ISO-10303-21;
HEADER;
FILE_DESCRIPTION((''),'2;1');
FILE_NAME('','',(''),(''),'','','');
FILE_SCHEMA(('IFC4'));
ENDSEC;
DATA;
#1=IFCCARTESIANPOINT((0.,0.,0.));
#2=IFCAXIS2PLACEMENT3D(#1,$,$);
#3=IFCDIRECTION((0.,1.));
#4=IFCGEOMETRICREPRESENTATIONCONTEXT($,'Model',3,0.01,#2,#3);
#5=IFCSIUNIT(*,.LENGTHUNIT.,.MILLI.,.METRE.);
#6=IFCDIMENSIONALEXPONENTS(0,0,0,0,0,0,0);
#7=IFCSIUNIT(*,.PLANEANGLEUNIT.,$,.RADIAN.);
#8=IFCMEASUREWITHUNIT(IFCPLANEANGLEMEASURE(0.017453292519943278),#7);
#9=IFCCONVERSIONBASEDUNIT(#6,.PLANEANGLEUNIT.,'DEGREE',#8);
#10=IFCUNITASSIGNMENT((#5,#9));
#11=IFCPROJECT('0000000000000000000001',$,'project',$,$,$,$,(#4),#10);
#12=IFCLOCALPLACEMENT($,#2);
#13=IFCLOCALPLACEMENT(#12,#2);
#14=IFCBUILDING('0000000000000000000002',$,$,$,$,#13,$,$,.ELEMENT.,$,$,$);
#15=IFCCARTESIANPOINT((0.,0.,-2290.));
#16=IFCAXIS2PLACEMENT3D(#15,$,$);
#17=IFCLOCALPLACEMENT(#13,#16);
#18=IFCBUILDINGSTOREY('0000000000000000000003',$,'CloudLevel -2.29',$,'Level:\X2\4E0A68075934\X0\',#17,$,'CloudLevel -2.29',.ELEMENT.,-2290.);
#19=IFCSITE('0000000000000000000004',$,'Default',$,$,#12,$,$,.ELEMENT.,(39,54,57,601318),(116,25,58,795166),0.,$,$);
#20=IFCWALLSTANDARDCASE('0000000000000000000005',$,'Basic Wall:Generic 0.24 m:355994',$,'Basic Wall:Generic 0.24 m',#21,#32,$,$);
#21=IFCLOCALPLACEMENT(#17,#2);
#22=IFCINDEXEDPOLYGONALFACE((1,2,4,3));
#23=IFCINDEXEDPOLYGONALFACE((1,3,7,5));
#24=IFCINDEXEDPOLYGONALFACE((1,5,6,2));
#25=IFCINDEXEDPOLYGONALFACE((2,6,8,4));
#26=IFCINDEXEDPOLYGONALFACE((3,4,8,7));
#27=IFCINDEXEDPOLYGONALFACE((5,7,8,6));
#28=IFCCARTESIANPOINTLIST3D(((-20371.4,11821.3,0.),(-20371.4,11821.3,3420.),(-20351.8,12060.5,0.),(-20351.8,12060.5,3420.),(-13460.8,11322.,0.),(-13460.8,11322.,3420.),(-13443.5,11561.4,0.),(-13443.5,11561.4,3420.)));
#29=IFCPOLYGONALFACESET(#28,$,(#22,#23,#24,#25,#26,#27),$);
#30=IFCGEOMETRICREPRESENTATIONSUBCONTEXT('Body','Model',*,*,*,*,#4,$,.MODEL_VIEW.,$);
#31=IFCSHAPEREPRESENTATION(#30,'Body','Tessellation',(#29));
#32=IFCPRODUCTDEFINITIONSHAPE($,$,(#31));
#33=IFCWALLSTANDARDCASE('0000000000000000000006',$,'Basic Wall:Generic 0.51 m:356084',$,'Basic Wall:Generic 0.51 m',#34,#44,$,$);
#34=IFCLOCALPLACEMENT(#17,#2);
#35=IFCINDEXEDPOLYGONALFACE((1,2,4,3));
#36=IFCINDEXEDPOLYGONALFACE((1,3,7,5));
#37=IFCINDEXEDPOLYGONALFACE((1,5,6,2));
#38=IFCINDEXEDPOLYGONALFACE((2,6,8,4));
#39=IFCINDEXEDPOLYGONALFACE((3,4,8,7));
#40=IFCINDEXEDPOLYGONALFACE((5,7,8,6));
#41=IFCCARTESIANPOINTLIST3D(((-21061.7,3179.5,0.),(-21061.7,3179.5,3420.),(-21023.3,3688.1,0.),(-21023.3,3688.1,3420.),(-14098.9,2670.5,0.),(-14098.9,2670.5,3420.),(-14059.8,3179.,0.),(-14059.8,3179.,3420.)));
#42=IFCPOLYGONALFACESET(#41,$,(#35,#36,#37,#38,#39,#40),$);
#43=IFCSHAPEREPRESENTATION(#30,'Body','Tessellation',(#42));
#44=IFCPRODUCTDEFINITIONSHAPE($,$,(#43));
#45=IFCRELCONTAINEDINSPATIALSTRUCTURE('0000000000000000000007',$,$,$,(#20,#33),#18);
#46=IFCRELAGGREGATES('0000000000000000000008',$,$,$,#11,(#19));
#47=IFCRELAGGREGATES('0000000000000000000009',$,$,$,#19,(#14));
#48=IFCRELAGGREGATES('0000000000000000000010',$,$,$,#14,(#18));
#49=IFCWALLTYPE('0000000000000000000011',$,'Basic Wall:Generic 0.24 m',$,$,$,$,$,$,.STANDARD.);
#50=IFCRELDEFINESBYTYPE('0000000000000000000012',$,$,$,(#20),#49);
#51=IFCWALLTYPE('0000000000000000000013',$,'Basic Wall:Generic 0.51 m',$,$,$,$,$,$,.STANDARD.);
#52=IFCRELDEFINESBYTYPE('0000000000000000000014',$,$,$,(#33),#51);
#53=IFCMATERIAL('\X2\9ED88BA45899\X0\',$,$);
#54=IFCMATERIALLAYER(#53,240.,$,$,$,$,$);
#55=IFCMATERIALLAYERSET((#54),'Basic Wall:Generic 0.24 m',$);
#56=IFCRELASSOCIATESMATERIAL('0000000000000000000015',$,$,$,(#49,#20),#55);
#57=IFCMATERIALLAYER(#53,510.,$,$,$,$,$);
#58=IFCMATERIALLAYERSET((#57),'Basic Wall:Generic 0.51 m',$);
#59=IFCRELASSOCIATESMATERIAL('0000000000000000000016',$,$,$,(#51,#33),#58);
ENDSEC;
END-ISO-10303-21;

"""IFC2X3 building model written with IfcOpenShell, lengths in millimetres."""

from ifc_helpers import new_model, entity, si_unit, converted_unit, direction, frame, origin, place, context, subcontext, project, spatial, polyline, outline, extrude, material, layer, layer_set, layer_usage, type_object, element, save


model = new_model("IFC2X3")

# Units and contexts
model_context = context("Model", 3, precision=0.01, world=origin(), true_north=direction((0.0, 1.0)))
body_context = subcontext(model_context, "Body", "Model", "MODEL_VIEW")
ifc_project = project(units=[si_unit("LENGTHUNIT", "METRE", prefix="MILLI"), converted_unit("PLANEANGLEUNIT", "DEGREE", entity("IfcPlaneAngleMeasure", 0.017453292519943278), si_unit("PLANEANGLEUNIT", "RADIAN"), dimensions=[0, 0, 0, 0, 0, 0, 0])], contexts=[model_context])

# Site, building, storey
site_placement = place(None, origin())
site = spatial("IfcSite", under=ifc_project, at=site_placement, Name="Default", CompositionType="ELEMENT", RefLatitude=(39, 54, 57, 601318), RefLongitude=(116, 25, 58, 795166), RefElevation=0.0)
building_placement = place(site_placement, origin())
building = spatial("IfcBuilding", under=site, at=building_placement, CompositionType="ELEMENT")
storey_placement = place(building_placement, frame((0.0, 0.0, -2290.0)))
storey = spatial("IfcBuildingStorey", under=building, at=storey_placement, Name="CloudLevel -2.29", ObjectType="Level:上标头", LongName="CloudLevel -2.29", CompositionType="ELEMENT", Elevation=-2290.0)

# Wall
ifc_material_1 = material(Name="默认墙")
ifc_layer_1 = layer(ifc_material_1, 240.0)
ifc_layer_set_1 = layer_set([ifc_layer_1], Name="Basic Wall:Generic 0.24 m")
ifc_layer_usage_1 = layer_usage(ifc_layer_set_1, "AXIS2", "NEGATIVE", 120.0)
wall_type_1 = type_object("IfcWallType", Name="Basic Wall:Generic 0.24 m", PredefinedType="STANDARD", material=ifc_layer_set_1)
wall_1_placement = place(storey_placement, frame((-13452.2, 11441.7, 0.0), z_axis=(0.0, 0.0, 1.0), x_axis=(-0.9974, 0.072065, 0.0)))
element("IfcWallStandardCase", 1, at=wall_1_placement, inside=storey, type_object=wall_type_1, material=ifc_layer_usage_1, Name="Basic Wall:Generic 0.24 m:355994", ObjectType="Basic Wall:Generic 0.24 m", context=body_context, shape_type="SweptSolid", body=[
    extrude(outline(polyline([(6926.3, -120.0), (6928.6, 120.0), (0.0, 120.0), (0.0, -120.0), (6926.3, -120.0)])), origin(), (0.0, 0.0, 1.0), 3420.0),
])

# Wall
ifc_layer_2 = layer(ifc_material_1, 510.0)
ifc_layer_set_2 = layer_set([ifc_layer_2], Name="Basic Wall:Generic 0.51 m")
ifc_layer_usage_2 = layer_usage(ifc_layer_set_2, "AXIS2", "NEGATIVE", 255.0)
wall_type_2 = type_object("IfcWallType", Name="Basic Wall:Generic 0.51 m", PredefinedType="STANDARD", material=ifc_layer_set_2)
wall_2_placement = place(storey_placement, frame((-21043.1, 3433.9, 0.0), z_axis=(0.0, 0.0, 1.0), x_axis=(0.997338, -0.072912, 0.0)))
element("IfcWallStandardCase", 2, at=wall_2_placement, inside=storey, type_object=wall_type_2, material=ifc_layer_usage_2, Name="Basic Wall:Generic 0.51 m:356084", ObjectType="Basic Wall:Generic 0.51 m", context=body_context, shape_type="SweptSolid", body=[
    extrude(outline(polyline([(6981.3, -255.0), (6983.3, 255.0), (1.2, 255.0), (0.0, -255.0), (6981.3, -255.0)])), origin(), (0.0, 0.0, 1.0), 3420.0),
])

save(model, "model.ifc")
